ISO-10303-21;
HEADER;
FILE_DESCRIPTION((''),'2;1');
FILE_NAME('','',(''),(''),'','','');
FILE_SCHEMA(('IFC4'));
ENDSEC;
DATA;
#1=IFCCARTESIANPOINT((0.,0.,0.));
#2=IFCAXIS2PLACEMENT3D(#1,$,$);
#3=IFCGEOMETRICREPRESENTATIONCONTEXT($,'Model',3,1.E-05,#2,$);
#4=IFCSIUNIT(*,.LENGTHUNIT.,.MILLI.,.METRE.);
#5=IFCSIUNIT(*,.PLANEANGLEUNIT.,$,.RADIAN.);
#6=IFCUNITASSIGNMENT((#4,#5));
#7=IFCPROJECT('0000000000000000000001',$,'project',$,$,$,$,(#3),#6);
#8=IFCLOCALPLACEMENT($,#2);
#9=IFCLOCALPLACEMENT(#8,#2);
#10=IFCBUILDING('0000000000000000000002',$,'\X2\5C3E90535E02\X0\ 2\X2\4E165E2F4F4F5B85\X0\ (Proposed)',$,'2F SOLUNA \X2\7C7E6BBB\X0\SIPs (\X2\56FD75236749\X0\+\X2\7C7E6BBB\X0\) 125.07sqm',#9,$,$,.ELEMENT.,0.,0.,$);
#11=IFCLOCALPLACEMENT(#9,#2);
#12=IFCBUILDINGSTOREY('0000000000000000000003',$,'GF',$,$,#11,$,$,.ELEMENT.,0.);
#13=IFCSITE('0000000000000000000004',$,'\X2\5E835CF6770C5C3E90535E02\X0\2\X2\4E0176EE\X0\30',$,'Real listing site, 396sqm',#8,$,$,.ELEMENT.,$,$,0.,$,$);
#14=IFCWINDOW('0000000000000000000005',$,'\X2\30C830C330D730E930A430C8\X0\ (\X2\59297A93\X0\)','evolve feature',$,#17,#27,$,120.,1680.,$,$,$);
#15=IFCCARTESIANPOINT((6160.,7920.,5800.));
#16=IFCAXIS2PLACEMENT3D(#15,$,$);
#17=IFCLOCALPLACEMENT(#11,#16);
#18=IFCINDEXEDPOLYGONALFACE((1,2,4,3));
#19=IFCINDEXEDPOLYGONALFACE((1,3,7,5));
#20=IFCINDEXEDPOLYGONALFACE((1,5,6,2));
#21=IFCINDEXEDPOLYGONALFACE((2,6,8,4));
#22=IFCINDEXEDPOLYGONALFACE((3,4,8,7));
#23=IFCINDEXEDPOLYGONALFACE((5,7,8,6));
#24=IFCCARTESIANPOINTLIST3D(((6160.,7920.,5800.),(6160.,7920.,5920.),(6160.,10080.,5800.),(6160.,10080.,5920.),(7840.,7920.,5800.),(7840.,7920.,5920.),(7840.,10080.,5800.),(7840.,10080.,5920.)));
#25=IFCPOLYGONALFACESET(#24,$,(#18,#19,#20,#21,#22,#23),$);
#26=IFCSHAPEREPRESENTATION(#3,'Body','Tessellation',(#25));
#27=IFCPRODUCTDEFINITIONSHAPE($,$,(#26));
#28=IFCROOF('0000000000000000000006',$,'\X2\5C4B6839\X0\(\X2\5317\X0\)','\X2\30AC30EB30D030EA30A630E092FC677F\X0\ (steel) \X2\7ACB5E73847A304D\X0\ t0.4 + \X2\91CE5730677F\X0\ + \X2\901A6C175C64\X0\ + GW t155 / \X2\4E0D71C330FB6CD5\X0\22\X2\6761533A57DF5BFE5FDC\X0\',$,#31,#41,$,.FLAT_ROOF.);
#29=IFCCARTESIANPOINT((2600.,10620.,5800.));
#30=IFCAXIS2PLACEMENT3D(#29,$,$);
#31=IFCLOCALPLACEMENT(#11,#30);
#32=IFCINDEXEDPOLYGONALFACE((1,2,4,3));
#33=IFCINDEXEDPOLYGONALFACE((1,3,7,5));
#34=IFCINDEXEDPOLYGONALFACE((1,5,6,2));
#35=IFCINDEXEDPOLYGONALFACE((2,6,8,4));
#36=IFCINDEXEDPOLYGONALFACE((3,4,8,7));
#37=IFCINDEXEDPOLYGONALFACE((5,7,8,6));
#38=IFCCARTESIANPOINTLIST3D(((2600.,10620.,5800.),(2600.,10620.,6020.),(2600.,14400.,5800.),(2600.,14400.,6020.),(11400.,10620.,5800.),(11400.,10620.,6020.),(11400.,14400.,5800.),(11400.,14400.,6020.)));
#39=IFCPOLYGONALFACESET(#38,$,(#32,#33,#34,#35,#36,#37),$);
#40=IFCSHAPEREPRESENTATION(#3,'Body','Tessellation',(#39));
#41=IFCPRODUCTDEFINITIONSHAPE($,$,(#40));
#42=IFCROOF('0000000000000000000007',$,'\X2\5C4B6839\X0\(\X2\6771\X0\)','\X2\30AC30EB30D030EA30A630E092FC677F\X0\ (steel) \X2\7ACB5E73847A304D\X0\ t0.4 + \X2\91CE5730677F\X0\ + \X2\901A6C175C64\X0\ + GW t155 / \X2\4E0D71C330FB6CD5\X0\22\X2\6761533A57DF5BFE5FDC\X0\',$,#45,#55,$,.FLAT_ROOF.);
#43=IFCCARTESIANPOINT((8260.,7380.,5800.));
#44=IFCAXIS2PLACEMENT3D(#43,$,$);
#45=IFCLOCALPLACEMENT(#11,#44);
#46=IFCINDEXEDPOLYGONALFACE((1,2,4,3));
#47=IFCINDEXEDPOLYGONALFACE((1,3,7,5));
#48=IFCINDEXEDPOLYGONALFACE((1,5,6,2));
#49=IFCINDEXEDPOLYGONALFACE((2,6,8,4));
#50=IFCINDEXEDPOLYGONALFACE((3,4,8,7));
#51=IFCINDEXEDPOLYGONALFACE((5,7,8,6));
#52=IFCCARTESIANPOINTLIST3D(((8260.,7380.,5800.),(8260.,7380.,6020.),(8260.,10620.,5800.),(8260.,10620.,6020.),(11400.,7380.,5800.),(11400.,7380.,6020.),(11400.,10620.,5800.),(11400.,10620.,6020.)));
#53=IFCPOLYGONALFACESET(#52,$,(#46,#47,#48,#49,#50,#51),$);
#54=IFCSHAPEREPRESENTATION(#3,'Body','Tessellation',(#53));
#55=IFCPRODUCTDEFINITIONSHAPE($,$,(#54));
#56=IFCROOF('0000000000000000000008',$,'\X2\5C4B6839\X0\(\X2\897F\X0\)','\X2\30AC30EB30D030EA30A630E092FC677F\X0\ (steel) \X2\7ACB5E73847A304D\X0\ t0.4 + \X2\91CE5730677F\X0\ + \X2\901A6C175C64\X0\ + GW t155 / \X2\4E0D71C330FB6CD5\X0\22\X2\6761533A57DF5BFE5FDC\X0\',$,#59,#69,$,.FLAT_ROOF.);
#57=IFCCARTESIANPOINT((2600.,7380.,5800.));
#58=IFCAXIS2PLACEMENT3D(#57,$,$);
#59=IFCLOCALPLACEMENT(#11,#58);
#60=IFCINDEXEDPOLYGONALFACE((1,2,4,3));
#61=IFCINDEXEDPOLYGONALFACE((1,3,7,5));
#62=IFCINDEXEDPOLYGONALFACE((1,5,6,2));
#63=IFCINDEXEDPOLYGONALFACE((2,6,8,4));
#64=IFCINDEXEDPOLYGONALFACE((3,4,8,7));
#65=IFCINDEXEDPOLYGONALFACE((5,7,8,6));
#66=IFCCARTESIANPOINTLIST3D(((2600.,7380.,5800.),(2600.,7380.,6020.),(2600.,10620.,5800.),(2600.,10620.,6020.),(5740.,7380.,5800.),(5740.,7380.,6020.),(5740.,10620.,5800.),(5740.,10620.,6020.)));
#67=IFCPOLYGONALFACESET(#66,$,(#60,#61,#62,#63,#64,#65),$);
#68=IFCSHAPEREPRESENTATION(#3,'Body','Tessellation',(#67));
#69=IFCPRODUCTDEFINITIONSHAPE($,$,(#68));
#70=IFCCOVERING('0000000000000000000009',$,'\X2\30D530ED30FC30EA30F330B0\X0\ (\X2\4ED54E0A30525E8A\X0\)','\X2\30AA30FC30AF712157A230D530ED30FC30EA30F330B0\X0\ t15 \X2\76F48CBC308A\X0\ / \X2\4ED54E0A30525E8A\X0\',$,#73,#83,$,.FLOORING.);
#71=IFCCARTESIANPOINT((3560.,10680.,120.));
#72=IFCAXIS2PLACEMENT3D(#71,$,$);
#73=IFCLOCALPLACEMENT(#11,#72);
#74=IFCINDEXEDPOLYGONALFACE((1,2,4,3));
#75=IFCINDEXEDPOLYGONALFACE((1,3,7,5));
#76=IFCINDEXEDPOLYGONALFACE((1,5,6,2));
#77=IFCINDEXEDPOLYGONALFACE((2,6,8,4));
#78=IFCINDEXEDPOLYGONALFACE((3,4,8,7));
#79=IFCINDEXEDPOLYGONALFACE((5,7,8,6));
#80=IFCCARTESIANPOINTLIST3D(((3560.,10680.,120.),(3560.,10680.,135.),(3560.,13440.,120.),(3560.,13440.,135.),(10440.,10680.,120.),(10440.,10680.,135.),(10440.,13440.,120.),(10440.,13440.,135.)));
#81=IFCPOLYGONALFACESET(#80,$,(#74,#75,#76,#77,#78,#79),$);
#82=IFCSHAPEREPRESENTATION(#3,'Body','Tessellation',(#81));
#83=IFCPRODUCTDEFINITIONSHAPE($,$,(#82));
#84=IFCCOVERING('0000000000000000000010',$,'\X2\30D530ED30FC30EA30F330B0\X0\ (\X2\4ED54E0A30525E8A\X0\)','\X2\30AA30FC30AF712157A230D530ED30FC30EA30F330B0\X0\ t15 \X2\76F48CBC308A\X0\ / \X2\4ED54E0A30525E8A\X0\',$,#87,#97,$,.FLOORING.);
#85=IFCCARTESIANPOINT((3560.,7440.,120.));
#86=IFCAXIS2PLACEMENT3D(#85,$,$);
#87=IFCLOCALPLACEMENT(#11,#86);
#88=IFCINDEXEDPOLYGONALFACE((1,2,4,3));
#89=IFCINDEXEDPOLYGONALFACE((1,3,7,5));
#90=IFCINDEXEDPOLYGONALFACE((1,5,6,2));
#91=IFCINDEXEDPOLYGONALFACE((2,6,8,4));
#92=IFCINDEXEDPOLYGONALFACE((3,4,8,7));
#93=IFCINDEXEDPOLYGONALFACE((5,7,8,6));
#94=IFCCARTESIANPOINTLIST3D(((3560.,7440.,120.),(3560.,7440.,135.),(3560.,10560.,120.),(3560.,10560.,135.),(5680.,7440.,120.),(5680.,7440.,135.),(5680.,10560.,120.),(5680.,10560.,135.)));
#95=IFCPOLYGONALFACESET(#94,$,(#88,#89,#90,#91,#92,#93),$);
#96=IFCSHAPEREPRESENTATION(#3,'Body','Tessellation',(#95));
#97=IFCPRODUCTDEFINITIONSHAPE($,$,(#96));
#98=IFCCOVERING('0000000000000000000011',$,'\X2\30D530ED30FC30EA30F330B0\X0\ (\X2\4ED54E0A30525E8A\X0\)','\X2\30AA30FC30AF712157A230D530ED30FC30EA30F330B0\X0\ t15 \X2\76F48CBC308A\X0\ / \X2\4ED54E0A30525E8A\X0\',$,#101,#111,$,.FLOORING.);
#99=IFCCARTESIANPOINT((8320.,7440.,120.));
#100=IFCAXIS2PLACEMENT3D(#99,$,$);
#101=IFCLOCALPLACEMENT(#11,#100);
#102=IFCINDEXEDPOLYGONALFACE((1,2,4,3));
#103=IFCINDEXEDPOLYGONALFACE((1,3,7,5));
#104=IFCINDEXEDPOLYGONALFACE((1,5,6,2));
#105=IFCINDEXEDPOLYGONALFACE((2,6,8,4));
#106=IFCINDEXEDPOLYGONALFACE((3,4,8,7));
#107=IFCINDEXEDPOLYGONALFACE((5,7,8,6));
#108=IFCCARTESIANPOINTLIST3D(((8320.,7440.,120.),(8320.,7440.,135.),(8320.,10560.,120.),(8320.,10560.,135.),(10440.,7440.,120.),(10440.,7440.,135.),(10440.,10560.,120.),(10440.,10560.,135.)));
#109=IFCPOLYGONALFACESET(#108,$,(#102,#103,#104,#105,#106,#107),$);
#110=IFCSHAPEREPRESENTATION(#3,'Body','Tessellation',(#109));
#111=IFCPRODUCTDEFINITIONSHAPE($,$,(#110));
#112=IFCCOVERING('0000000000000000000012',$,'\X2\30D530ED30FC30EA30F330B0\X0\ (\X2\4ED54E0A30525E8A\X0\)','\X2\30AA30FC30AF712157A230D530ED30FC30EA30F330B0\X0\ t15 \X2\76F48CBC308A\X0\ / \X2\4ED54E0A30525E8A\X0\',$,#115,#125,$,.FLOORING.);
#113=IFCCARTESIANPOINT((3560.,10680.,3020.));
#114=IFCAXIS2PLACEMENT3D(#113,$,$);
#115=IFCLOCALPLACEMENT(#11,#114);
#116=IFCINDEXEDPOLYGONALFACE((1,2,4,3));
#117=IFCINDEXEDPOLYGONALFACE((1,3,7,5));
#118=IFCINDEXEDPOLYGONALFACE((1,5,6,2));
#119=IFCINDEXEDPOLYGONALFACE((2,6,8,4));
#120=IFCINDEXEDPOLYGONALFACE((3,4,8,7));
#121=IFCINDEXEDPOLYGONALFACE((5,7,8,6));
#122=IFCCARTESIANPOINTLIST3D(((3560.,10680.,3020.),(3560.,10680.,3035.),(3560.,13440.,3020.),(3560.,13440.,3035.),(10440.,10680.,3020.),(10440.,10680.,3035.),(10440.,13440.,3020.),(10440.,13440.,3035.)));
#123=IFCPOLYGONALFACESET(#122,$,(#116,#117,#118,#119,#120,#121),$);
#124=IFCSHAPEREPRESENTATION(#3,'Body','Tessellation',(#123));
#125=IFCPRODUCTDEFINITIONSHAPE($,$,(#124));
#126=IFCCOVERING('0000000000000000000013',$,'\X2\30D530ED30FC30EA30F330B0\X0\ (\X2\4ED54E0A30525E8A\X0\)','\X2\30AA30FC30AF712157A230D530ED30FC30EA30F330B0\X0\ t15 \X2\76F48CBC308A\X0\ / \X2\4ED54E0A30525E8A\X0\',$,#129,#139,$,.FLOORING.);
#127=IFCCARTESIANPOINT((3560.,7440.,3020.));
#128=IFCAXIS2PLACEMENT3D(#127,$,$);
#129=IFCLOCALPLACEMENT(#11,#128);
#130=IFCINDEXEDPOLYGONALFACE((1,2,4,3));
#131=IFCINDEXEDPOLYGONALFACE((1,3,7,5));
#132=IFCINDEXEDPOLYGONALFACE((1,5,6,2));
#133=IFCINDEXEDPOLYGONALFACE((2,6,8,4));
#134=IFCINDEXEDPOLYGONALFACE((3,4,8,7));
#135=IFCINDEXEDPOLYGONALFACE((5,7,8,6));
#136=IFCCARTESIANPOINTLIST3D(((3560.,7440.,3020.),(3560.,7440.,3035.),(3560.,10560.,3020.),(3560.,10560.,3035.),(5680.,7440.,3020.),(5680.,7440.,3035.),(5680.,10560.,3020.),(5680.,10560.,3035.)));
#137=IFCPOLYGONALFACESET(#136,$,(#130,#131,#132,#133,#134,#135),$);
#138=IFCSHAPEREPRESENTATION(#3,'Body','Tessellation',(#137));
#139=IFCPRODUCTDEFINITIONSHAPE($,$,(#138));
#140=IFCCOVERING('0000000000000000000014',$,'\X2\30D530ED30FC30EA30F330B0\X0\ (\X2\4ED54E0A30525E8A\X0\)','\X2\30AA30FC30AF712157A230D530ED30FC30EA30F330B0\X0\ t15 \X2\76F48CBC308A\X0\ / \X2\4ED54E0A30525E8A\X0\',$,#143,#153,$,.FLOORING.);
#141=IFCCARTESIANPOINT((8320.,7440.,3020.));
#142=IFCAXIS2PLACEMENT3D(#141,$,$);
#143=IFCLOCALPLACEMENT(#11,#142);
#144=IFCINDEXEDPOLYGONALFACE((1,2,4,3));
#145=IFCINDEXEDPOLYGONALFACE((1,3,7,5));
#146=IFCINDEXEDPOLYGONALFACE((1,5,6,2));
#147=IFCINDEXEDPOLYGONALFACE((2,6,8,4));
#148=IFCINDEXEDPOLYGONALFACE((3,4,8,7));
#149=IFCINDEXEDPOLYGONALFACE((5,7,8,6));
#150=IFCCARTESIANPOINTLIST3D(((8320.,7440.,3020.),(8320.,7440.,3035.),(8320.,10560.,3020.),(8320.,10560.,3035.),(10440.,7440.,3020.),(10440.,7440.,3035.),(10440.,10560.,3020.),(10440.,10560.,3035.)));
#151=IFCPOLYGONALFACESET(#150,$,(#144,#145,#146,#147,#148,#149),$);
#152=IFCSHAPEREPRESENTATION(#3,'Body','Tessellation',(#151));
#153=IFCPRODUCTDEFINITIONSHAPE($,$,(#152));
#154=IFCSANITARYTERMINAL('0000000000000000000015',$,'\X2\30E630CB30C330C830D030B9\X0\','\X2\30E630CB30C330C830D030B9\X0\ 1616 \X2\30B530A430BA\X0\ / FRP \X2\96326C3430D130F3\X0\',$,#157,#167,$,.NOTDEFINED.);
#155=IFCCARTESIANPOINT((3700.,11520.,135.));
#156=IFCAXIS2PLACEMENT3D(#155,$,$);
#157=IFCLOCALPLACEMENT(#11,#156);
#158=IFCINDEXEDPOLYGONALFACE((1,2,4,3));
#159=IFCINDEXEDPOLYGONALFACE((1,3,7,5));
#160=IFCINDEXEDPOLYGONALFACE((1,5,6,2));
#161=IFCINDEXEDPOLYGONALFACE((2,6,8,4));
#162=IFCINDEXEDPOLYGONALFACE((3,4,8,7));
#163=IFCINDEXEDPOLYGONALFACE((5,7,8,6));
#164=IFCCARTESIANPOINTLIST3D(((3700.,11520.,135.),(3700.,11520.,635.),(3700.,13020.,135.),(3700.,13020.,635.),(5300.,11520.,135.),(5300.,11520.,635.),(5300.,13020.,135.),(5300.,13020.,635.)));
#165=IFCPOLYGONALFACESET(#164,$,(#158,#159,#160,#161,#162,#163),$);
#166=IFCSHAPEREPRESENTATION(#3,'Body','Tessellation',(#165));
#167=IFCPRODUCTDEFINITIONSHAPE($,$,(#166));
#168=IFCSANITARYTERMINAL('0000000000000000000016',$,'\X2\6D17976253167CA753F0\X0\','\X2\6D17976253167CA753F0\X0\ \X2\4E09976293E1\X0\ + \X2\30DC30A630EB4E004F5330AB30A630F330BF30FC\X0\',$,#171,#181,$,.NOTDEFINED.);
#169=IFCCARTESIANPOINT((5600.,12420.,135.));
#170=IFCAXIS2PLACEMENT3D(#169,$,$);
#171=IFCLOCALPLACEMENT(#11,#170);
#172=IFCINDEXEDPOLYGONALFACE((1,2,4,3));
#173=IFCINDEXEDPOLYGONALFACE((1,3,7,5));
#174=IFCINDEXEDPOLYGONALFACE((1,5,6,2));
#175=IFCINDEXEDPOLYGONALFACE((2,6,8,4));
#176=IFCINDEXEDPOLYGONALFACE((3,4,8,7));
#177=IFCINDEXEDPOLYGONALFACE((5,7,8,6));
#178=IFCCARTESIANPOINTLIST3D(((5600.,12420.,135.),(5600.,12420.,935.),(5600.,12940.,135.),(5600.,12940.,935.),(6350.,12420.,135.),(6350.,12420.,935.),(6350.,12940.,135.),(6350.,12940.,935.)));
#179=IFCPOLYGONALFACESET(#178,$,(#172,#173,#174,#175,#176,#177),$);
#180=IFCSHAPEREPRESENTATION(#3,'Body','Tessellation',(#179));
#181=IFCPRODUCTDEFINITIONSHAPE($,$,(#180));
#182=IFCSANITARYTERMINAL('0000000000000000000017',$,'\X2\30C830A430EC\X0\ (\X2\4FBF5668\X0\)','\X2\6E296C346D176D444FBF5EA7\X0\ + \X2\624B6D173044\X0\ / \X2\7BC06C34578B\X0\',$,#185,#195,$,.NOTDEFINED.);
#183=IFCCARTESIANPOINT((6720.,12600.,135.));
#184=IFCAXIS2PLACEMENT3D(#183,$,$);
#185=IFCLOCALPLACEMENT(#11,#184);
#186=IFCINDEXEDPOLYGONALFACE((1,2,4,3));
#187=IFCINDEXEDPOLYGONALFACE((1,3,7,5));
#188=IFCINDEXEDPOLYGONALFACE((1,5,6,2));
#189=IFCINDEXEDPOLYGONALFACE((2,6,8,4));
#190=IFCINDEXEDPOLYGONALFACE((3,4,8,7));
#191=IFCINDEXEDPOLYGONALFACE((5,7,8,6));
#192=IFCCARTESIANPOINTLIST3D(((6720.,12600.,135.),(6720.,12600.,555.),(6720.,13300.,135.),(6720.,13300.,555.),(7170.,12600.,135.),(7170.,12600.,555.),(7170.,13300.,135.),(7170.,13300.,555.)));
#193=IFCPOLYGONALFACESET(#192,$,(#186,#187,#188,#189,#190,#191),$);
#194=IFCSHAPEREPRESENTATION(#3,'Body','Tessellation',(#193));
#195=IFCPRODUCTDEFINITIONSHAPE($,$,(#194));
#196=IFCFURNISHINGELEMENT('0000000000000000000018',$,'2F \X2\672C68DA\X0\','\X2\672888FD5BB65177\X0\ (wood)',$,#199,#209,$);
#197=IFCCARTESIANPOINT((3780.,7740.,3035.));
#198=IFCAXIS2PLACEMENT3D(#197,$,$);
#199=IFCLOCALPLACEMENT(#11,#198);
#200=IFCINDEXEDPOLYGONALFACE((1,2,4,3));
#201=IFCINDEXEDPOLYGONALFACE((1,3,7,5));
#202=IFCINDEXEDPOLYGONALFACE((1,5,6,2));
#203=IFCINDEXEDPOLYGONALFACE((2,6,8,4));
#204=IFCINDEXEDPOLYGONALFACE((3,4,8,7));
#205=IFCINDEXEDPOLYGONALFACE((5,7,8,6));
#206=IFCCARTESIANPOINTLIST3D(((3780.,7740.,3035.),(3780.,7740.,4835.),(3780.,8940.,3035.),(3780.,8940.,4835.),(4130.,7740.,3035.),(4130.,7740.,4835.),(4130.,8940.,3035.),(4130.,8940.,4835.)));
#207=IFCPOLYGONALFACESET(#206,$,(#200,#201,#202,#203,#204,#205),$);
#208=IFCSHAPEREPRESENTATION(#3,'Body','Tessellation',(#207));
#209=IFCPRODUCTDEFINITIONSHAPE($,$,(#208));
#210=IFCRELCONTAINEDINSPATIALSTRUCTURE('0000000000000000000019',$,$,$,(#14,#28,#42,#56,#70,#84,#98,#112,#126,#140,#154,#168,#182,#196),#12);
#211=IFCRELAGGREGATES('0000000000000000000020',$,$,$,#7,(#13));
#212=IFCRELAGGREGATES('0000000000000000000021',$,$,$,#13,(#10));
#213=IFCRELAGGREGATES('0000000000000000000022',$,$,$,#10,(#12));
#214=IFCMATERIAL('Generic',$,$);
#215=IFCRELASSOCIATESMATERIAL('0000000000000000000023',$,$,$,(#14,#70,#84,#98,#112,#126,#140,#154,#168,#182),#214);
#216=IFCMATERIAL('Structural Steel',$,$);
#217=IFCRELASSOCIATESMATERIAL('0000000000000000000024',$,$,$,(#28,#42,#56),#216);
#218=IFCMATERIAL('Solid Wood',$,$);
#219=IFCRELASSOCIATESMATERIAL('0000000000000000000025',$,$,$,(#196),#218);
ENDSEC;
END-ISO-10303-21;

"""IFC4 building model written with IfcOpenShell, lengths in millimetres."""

from ifc_helpers import new_model, si_unit, frame, frame_2d, origin, place, context, project, spatial, rectangle, extrude, material, element, save


model = new_model("IFC4")

# Units and contexts
model_context = context("Model", 3, precision=1e-05, world=origin())
ifc_project = project(units=[si_unit("LENGTHUNIT", "METRE", prefix="MILLI"), si_unit("PLANEANGLEUNIT", "RADIAN")], contexts=[model_context])

# Site, building, storey
site_placement = place(None, origin())
site = spatial("IfcSite", under=ifc_project, at=site_placement, Name="広島県尾道市2丁目30", ObjectType="Real listing site, 396sqm", CompositionType="ELEMENT", RefElevation=0.0)
building_placement = place(site_placement, origin())
building = spatial("IfcBuilding", under=site, at=building_placement, Name="尾道市 2世帯住宅 (Proposed)", ObjectType="2F SOLUNA 籾殻SIPs (国産杉+籾殻) 125.07sqm", CompositionType="ELEMENT", ElevationOfRefHeight=0.0, ElevationOfTerrain=0.0)
storey_placement = place(building_placement, origin())
storey = spatial("IfcBuildingStorey", under=building, at=storey_placement, Name="GF", CompositionType="ELEMENT", Elevation=0.0)

# Shared definitions
ifc_material_1 = material(Name="Solid Wood")

# Window
ifc_material_2 = material(Name="Generic")
window_1_placement = place(storey_placement, frame((6160.0, 7920.0, 5800.0)))
element("IfcWindow", 1, at=window_1_placement, inside=storey, material=ifc_material_2, Name="トップライト (天窓)", Description="evolve feature", OverallHeight=120.0, OverallWidth=1680.0, context=model_context, shape_type="SweptSolid", body=[
    extrude(rectangle(XDim=1680.0, YDim=2160.0, at=frame_2d((840.0, 1080.0))), frame((6160.0, 7920.0, 5800.0)), (0.0, 0.0, 1.0), 120.0),
])

# Roofs
ifc_material_3 = material(Name="Structural Steel")
roof_1_placement = place(storey_placement, frame((2600.0, 10620.0, 5800.0)))
element("IfcRoof", 2, at=roof_1_placement, inside=storey, material=ifc_material_3, Name="屋根(北)", Description="ガルバリウム鋼板 (steel) 立平葺き t0.4 + 野地板 + 通気層 + GW t155 / 不燃・法22条区域対応", PredefinedType="FLAT_ROOF", context=model_context, shape_type="SweptSolid", body=[
    extrude(rectangle(XDim=8800.0, YDim=3780.0, at=frame_2d((4400.0, 1890.0))), frame((2600.0, 10620.0, 5800.0)), (0.0, 0.0, 1.0), 220.0),
])
roof_2_placement = place(storey_placement, frame((8260.0, 7380.0, 5800.0)))
element("IfcRoof", 3, at=roof_2_placement, inside=storey, material=ifc_material_3, Name="屋根(東)", Description="ガルバリウム鋼板 (steel) 立平葺き t0.4 + 野地板 + 通気層 + GW t155 / 不燃・法22条区域対応", PredefinedType="FLAT_ROOF", context=model_context, shape_type="SweptSolid", body=[
    extrude(rectangle(XDim=3140.0, YDim=3240.0, at=frame_2d((1570.0, 1620.0))), frame((8260.0, 7380.0, 5800.0)), (0.0, 0.0, 1.0), 220.0),
])
roof_3_placement = place(storey_placement, frame((2600.0, 7380.0, 5800.0)))
element("IfcRoof", 4, at=roof_3_placement, inside=storey, material=ifc_material_3, Name="屋根(西)", Description="ガルバリウム鋼板 (steel) 立平葺き t0.4 + 野地板 + 通気層 + GW t155 / 不燃・法22条区域対応", PredefinedType="FLAT_ROOF", context=model_context, shape_type="SweptSolid", body=[
    extrude(rectangle(XDim=3140.0, YDim=3240.0, at=frame_2d((1570.0, 1620.0))), frame((2600.0, 7380.0, 5800.0)), (0.0, 0.0, 1.0), 220.0),
])

# Coverings
covering_1_placement = place(storey_placement, frame((3560.0, 10680.0, 120.0)))
element("IfcCovering", 5, at=covering_1_placement, inside=storey, material=ifc_material_2, Name="フローリング (仕上げ床)", Description="オーク無垢フローリング t15 直貼り / 仕上げ床", PredefinedType="FLOORING", context=model_context, shape_type="SweptSolid", body=[
    extrude(rectangle(XDim=6880.0, YDim=2760.0, at=frame_2d((3440.0, 1380.0))), frame((3560.0, 10680.0, 120.0)), (0.0, 0.0, 1.0), 15.0),
])
covering_2_placement = place(storey_placement, frame((3560.0, 7440.0, 120.0)))
element("IfcCovering", 6, at=covering_2_placement, inside=storey, material=ifc_material_2, Name="フローリング (仕上げ床)", Description="オーク無垢フローリング t15 直貼り / 仕上げ床", PredefinedType="FLOORING", context=model_context, shape_type="SweptSolid", body=[
    extrude(rectangle(XDim=2120.0, YDim=3120.0, at=frame_2d((1060.0, 1560.0))), frame((3560.0, 7440.0, 120.0)), (0.0, 0.0, 1.0), 15.0),
])
covering_3_placement = place(storey_placement, frame((8320.0, 7440.0, 120.0)))
element("IfcCovering", 7, at=covering_3_placement, inside=storey, material=ifc_material_2, Name="フローリング (仕上げ床)", Description="オーク無垢フローリング t15 直貼り / 仕上げ床", PredefinedType="FLOORING", context=model_context, shape_type="SweptSolid", body=[
    extrude(rectangle(XDim=2120.0, YDim=3120.0, at=frame_2d((1060.0, 1560.0))), frame((8320.0, 7440.0, 120.0)), (0.0, 0.0, 1.0), 15.0),
])
covering_4_placement = place(storey_placement, frame((3560.0, 10680.0, 3020.0)))
element("IfcCovering", 8, at=covering_4_placement, inside=storey, material=ifc_material_2, Name="フローリング (仕上げ床)", Description="オーク無垢フローリング t15 直貼り / 仕上げ床", PredefinedType="FLOORING", context=model_context, shape_type="SweptSolid", body=[
    extrude(rectangle(XDim=6880.0, YDim=2760.0, at=frame_2d((3440.0, 1380.0))), frame((3560.0, 10680.0, 3020.0)), (0.0, 0.0, 1.0), 15.0),
])
covering_5_placement = place(storey_placement, frame((3560.0, 7440.0, 3020.0)))
element("IfcCovering", 9, at=covering_5_placement, inside=storey, material=ifc_material_2, Name="フローリング (仕上げ床)", Description="オーク無垢フローリング t15 直貼り / 仕上げ床", PredefinedType="FLOORING", context=model_context, shape_type="SweptSolid", body=[
    extrude(rectangle(XDim=2120.0, YDim=3120.0, at=frame_2d((1060.0, 1560.0))), frame((3560.0, 7440.0, 3020.0)), (0.0, 0.0, 1.0), 15.0),
])
covering_6_placement = place(storey_placement, frame((8320.0, 7440.0, 3020.0)))
element("IfcCovering", 10, at=covering_6_placement, inside=storey, material=ifc_material_2, Name="フローリング (仕上げ床)", Description="オーク無垢フローリング t15 直貼り / 仕上げ床", PredefinedType="FLOORING", context=model_context, shape_type="SweptSolid", body=[
    extrude(rectangle(XDim=2120.0, YDim=3120.0, at=frame_2d((1060.0, 1560.0))), frame((8320.0, 7440.0, 3020.0)), (0.0, 0.0, 1.0), 15.0),
])

# Sanitary terminals
sanitary_terminal_1_placement = place(storey_placement, frame((3700.0, 11520.0, 135.0)))
element("IfcSanitaryTerminal", 11, at=sanitary_terminal_1_placement, inside=storey, material=ifc_material_2, Name="ユニットバス", Description="ユニットバス 1616 サイズ / FRP 防水パン", PredefinedType="NOTDEFINED", context=model_context, shape_type="SweptSolid", body=[
    extrude(rectangle(XDim=1600.0, YDim=1500.0, at=frame_2d((800.0, 750.0))), frame((3700.0, 11520.0, 135.0)), (0.0, 0.0, 1.0), 500.0),
])
sanitary_terminal_2_placement = place(storey_placement, frame((5600.0, 12420.0, 135.0)))
element("IfcSanitaryTerminal", 12, at=sanitary_terminal_2_placement, inside=storey, material=ifc_material_2, Name="洗面化粧台", Description="洗面化粧台 三面鏡 + ボウル一体カウンター", PredefinedType="NOTDEFINED", context=model_context, shape_type="SweptSolid", body=[
    extrude(rectangle(XDim=750.0, YDim=520.0, at=frame_2d((375.0, 260.0))), frame((5600.0, 12420.0, 135.0)), (0.0, 0.0, 1.0), 800.0),
])
sanitary_terminal_3_placement = place(storey_placement, frame((6720.0, 12600.0, 135.0)))
element("IfcSanitaryTerminal", 13, at=sanitary_terminal_3_placement, inside=storey, material=ifc_material_2, Name="トイレ (便器)", Description="温水洗浄便座 + 手洗い / 節水型", PredefinedType="NOTDEFINED", context=model_context, shape_type="SweptSolid", body=[
    extrude(rectangle(XDim=450.0, YDim=700.0, at=frame_2d((225.0, 350.0))), frame((6720.0, 12600.0, 135.0)), (0.0, 0.0, 1.0), 420.0),
])

# Furnishing element
furnishing_placement = place(storey_placement, frame((3780.0, 7740.0, 3035.0)))
element("IfcFurnishingElement", 14, at=furnishing_placement, inside=storey, material=ifc_material_1, Name="2F 本棚", Description="木製家具 (wood)", context=model_context, shape_type="SweptSolid", body=[
    extrude(rectangle(XDim=350.0, YDim=1200.0, at=frame_2d((175.0, 600.0))), frame((3780.0, 7740.0, 3035.0)), (0.0, 0.0, 1.0), 1800.0),
])

save(model, "model.ifc")
